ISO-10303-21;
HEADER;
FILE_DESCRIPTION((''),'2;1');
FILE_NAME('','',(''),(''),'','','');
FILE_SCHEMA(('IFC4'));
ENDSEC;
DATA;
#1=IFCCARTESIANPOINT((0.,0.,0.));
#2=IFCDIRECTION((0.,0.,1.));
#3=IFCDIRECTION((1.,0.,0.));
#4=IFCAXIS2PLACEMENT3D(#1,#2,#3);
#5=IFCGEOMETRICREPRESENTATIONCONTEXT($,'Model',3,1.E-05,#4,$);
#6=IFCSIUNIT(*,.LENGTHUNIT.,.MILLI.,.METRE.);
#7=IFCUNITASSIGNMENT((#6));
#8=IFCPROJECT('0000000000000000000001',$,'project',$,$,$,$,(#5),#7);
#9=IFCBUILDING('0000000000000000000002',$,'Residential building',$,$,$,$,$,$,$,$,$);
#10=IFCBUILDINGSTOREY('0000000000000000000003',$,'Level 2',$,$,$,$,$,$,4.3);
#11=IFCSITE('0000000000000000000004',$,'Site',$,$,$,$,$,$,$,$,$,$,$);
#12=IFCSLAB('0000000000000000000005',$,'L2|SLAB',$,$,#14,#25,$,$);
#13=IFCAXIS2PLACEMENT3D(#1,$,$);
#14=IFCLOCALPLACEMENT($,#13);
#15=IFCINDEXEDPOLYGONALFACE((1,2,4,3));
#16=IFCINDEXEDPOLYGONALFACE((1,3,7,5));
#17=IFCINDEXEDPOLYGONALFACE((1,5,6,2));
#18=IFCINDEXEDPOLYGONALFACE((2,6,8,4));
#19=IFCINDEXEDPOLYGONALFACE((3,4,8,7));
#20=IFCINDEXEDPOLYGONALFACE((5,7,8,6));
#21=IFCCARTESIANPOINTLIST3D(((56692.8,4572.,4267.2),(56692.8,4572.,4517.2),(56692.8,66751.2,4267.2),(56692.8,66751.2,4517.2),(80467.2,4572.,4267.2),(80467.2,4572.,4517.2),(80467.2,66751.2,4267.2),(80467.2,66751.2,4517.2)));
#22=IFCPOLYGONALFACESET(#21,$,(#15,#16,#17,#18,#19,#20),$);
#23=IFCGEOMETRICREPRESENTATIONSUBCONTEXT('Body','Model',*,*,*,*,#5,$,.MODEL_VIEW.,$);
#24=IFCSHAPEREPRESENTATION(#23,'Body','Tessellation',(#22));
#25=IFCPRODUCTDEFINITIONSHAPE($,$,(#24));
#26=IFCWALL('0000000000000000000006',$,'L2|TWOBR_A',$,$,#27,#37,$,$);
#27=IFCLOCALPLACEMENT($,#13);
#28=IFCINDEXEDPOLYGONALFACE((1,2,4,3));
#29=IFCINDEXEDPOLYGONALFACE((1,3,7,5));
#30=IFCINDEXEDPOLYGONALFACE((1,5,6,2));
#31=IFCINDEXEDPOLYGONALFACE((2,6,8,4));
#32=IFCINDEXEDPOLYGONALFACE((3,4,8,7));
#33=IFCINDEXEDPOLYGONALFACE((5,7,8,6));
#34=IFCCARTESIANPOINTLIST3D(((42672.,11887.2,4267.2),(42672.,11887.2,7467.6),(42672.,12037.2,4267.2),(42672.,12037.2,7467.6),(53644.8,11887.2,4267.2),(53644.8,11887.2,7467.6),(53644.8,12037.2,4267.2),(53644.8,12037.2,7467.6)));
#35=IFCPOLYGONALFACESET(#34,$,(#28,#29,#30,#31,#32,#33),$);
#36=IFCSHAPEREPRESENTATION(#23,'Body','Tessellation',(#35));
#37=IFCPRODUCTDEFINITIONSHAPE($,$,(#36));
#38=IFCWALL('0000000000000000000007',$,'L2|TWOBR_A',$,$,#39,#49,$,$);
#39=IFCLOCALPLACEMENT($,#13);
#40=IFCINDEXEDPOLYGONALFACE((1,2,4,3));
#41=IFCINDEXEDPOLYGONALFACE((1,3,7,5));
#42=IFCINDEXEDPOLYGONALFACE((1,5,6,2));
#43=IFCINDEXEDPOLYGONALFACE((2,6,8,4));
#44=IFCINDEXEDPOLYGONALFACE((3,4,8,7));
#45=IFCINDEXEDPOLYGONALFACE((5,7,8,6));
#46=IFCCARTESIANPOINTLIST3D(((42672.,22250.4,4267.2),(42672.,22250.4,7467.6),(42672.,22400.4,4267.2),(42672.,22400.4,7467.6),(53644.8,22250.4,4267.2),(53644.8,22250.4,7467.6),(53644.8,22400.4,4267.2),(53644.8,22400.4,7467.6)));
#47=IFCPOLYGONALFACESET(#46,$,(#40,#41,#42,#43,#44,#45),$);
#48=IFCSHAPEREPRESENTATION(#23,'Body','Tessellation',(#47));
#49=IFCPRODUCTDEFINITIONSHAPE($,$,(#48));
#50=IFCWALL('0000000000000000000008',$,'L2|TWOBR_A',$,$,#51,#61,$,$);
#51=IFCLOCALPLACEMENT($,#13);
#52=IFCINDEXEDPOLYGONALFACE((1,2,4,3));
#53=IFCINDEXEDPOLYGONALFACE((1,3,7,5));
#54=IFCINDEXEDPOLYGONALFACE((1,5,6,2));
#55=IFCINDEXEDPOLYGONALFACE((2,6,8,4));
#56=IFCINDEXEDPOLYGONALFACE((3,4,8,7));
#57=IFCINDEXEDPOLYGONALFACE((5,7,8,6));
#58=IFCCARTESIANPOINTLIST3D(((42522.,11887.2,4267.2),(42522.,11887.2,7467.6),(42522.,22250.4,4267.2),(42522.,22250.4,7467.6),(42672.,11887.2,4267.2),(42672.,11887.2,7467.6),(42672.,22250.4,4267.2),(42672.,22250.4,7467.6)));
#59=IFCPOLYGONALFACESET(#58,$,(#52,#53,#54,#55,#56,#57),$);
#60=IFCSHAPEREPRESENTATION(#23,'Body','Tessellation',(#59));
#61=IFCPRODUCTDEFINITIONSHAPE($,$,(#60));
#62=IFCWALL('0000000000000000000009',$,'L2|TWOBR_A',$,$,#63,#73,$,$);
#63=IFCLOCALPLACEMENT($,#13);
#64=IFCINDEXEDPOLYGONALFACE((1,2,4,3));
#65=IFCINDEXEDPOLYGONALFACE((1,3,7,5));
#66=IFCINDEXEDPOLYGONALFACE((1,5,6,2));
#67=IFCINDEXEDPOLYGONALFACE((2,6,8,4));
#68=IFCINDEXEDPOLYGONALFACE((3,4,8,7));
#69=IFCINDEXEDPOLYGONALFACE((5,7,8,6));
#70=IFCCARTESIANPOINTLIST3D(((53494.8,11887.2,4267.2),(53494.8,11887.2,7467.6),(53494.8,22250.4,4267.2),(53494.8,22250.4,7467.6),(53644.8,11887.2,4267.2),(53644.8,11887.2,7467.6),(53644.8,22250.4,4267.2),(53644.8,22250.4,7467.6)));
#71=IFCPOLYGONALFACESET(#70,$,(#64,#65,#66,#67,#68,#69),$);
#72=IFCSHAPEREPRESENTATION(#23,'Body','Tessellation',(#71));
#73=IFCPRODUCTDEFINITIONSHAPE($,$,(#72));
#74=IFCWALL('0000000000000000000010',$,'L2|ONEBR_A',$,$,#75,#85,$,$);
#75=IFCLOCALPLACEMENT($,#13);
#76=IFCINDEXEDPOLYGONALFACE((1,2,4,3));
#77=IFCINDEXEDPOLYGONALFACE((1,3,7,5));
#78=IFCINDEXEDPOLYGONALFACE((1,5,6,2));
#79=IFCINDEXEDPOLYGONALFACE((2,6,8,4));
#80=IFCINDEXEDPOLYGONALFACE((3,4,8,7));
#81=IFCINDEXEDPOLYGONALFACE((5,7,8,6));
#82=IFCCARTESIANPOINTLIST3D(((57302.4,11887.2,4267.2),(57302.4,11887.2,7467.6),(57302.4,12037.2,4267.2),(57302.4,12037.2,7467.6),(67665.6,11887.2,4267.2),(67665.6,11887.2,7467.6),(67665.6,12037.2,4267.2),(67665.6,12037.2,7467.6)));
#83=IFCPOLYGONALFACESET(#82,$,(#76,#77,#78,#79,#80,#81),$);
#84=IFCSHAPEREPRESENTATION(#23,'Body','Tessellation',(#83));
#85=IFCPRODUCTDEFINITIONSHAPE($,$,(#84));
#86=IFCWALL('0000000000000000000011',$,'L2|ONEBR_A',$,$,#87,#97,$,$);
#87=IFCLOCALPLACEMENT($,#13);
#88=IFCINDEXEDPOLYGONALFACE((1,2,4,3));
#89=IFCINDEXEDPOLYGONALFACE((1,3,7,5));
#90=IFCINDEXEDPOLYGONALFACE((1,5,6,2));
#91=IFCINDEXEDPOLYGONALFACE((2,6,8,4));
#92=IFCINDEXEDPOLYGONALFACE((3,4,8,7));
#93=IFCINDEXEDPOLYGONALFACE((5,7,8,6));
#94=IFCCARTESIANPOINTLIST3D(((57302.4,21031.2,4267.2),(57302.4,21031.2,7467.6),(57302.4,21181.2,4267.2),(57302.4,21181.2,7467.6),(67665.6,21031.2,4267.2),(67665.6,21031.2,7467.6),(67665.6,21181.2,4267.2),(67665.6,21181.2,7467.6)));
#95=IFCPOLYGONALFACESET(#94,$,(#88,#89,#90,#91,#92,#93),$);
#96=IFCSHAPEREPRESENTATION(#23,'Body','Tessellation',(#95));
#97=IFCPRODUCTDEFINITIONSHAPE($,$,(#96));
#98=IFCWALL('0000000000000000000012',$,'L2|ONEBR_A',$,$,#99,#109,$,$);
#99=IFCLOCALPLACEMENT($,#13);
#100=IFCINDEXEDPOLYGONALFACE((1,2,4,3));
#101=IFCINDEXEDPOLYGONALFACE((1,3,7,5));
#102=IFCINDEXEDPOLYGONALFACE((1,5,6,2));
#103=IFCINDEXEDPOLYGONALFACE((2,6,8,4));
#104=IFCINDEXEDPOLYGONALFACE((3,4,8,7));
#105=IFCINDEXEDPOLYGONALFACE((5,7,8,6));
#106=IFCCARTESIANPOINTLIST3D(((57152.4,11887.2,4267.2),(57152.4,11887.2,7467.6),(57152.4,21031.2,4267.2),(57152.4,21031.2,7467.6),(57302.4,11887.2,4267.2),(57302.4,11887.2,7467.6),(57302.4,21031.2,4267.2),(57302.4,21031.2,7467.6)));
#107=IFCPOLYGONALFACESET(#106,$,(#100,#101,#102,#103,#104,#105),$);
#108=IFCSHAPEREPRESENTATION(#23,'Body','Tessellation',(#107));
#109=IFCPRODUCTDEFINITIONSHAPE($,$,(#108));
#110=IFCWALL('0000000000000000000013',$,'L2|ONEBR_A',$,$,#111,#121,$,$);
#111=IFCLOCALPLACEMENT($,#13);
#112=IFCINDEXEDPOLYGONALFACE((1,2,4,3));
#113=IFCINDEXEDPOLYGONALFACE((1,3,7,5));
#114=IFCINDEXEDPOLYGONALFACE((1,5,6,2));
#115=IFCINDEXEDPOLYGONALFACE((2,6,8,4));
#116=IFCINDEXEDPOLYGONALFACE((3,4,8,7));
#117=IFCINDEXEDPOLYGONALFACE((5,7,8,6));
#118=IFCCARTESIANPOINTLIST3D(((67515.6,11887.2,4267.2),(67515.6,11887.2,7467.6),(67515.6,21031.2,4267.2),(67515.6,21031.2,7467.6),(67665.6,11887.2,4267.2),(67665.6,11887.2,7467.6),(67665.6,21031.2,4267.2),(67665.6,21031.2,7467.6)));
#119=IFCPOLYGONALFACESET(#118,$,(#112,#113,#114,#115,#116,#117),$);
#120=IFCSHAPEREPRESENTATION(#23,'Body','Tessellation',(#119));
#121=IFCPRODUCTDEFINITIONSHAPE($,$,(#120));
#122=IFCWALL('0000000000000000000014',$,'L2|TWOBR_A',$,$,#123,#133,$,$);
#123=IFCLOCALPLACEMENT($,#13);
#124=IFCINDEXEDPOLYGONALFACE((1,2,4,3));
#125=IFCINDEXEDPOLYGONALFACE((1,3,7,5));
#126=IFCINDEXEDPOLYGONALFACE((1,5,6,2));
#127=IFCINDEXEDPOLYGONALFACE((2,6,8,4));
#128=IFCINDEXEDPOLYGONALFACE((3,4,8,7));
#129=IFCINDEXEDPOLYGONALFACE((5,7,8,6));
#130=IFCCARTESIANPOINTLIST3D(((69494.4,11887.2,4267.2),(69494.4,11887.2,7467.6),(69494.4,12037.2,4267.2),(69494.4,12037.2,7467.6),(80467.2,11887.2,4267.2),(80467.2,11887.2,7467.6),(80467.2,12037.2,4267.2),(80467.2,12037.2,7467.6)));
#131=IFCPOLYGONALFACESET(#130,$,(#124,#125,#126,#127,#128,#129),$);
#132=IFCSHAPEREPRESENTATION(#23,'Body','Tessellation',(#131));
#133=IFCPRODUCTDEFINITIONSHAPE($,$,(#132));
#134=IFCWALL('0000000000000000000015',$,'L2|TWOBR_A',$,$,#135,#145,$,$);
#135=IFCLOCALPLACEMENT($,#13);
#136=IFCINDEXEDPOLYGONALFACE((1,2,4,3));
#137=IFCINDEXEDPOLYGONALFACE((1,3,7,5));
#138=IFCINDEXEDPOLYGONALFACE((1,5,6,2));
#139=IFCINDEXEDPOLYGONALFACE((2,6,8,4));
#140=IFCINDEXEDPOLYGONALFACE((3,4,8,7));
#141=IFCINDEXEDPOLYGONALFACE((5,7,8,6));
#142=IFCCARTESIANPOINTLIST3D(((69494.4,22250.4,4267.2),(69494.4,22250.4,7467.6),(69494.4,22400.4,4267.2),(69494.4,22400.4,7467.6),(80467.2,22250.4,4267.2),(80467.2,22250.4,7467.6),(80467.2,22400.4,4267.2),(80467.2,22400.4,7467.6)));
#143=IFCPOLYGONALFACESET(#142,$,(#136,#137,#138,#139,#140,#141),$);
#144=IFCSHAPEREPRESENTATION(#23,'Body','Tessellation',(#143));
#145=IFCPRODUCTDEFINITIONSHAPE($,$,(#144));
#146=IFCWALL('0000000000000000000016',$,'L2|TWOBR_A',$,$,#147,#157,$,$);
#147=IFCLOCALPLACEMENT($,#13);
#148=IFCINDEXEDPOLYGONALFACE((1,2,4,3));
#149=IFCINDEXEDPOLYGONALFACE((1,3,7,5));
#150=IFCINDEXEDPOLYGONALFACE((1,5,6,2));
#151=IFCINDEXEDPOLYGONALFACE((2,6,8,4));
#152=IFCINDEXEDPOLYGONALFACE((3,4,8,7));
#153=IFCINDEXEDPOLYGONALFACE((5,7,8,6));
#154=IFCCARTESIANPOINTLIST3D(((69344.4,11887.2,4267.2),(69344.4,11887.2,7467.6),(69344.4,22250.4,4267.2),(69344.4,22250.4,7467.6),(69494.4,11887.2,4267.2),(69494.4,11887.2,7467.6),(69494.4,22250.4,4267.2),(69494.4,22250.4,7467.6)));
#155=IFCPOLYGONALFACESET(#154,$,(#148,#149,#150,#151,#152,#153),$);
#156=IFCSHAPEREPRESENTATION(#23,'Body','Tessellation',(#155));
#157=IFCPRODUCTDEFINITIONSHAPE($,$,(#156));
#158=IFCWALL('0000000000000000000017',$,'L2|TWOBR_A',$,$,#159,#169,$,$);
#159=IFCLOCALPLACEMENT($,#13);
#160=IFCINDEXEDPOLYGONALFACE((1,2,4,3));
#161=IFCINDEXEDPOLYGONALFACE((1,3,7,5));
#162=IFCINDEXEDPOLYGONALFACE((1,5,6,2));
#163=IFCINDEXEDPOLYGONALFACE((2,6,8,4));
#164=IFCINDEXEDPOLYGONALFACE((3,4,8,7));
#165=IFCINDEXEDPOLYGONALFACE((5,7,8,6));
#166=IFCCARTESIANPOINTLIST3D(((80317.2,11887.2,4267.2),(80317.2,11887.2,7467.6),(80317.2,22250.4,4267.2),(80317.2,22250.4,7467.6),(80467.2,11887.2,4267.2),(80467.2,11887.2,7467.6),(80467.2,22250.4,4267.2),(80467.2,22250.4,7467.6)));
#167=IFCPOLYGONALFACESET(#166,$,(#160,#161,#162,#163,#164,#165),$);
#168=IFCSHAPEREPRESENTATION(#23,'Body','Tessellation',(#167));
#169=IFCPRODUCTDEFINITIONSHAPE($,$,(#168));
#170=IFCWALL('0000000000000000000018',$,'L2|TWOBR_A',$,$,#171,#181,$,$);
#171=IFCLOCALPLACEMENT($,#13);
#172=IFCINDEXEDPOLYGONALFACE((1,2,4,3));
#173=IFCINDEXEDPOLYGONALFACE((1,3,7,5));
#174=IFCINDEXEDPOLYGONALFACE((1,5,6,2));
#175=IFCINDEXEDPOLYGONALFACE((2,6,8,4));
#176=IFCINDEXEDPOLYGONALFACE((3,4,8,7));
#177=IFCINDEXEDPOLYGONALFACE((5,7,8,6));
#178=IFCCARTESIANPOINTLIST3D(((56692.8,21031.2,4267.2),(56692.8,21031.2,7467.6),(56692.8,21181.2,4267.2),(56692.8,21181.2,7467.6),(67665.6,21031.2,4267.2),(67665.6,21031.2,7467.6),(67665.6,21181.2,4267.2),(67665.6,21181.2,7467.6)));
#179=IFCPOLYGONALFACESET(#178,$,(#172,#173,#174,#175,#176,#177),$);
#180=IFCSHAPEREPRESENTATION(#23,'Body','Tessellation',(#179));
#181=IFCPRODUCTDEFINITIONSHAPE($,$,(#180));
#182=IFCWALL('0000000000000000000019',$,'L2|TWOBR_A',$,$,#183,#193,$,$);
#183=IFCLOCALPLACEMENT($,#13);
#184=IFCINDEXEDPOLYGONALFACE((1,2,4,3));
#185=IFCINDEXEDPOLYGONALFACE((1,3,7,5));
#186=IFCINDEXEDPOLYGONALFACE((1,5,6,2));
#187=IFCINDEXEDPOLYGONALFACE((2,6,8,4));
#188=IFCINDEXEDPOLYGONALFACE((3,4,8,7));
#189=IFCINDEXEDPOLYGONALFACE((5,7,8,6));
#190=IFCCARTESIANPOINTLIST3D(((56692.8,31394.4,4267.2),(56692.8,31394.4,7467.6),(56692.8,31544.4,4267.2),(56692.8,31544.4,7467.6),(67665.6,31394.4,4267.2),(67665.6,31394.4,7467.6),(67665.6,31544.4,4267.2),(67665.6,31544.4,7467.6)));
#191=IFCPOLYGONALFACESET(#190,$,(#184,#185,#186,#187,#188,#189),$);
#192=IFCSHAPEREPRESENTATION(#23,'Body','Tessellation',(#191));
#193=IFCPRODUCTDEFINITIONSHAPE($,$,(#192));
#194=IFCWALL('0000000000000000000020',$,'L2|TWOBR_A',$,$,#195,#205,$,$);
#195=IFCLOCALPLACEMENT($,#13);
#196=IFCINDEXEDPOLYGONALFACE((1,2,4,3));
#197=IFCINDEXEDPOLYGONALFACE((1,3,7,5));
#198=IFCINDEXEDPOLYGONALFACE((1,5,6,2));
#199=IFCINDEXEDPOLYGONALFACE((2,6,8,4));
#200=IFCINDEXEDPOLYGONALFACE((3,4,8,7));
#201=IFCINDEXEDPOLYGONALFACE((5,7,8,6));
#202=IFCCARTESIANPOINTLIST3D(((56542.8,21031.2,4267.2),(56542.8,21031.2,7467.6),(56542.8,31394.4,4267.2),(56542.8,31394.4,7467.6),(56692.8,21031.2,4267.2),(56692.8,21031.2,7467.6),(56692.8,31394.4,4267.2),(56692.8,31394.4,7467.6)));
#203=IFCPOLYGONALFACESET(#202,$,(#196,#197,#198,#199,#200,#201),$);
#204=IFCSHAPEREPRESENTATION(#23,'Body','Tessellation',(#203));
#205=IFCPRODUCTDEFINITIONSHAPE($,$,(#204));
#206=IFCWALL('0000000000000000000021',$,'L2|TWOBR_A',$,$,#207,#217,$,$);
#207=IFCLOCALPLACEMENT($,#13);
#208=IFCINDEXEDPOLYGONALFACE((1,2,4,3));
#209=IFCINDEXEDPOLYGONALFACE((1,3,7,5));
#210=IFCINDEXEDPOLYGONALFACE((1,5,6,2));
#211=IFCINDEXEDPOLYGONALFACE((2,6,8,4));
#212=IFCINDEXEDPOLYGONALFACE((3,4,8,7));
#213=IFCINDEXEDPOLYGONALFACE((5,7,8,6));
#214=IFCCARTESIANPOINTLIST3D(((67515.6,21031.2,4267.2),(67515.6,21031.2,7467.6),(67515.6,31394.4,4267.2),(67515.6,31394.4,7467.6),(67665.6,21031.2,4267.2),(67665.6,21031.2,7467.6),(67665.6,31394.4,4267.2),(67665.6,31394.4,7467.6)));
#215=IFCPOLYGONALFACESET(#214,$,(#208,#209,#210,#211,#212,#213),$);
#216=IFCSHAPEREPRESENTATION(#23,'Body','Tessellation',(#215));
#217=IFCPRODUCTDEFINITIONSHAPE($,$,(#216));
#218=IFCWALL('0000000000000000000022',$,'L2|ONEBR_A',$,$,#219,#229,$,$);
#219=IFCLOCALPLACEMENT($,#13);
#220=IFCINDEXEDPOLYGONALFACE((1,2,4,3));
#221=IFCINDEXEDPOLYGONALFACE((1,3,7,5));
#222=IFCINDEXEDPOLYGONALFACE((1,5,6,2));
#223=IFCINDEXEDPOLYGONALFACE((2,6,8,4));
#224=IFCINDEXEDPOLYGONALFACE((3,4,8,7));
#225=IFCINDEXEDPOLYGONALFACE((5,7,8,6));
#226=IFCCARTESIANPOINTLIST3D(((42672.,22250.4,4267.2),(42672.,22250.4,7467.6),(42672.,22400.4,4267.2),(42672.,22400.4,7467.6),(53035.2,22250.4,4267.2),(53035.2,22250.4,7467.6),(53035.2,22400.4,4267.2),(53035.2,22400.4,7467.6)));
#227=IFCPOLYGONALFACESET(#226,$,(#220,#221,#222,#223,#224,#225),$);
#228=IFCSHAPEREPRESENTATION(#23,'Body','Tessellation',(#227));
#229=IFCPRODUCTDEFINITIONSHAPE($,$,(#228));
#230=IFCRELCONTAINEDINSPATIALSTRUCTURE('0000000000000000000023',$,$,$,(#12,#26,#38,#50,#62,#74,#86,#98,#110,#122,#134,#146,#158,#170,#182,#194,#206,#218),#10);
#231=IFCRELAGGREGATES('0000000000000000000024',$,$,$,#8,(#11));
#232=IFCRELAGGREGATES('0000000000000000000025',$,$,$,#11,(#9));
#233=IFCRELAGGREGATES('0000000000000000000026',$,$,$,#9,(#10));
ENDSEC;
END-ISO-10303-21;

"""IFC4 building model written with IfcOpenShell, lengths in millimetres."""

from ifc_helpers import new_model, si_unit, frame, origin_with_axes, place, context, subcontext, project, spatial, indexed_curve, outline, extrude, element, save


model = new_model("IFC4")

# Units and contexts
model_context = context("Model", 3, precision=1e-05, world=origin_with_axes())
body_context = subcontext(model_context, "Body", "Model", "MODEL_VIEW")
ifc_project = project(units=[si_unit("LENGTHUNIT", "METRE", prefix="MILLI")], contexts=[model_context])

# Site, building, storey
site = spatial("IfcSite", under=ifc_project, Name="Site")
building = spatial("IfcBuilding", under=site, Name="Residential building")
storey = spatial("IfcBuildingStorey", under=building, Name="Level 2", Elevation=4.3)

# Slab
slab_placement = place(None, frame((56692.8, 4572.0, 4267.2), z_axis=(0.0, 0.0, 1.0), x_axis=(1.0, 0.0, 0.0)))
element("IfcSlab", 1, at=slab_placement, inside=storey, Name="L2|SLAB", context=body_context, shape_type="SweptSolid", body=[
    extrude(outline(indexed_curve([(0.0, 0.0), (23774.4, 0.0), (23774.4, 62179.2), (0.0, 62179.2), (0.0, 0.0)])), None, (0.0, 0.0, 1.0), 250.0),
])

# Walls
for number, where, z_axis, x_axis, name in (
    (2, (42672.0, 11887.2, 4267.2), (0.0, 0.0, 1.0), (1.0, 0.0, 0.0), "L2|TWOBR_A"),
    (3, (42672.0, 22250.4, 4267.2), (0.0, 0.0, 1.0), (1.0, 0.0, 0.0), "L2|TWOBR_A"),
):
    element("IfcWall", number, at=place(None, frame(where, z_axis=z_axis, x_axis=x_axis)), inside=storey, Name=name, context=body_context, shape_type="SweptSolid", body=[
        extrude(outline(indexed_curve([(0.0, 0.0), (0.0, 150.0), (10972.8, 150.0), (10972.8, 0.0), (0.0, 0.0)], self_intersect=False)), origin_with_axes(), (0.0, 0.0, 1.0), 3200.4),
    ])
for number, where, z_axis, x_axis, name in (
    (4, (42672.0, 11887.2, 4267.2), (0.0, 0.0, 1.0), (0.0, 1.0, 0.0), "L2|TWOBR_A"),
    (5, (53644.8, 11887.2, 4267.2), (0.0, 0.0, 1.0), (0.0, 1.0, 0.0), "L2|TWOBR_A"),
    (6, (57302.4, 11887.2, 4267.2), (0.0, 0.0, 1.0), (1.0, 0.0, 0.0), "L2|ONEBR_A"),
    (7, (57302.4, 21031.2, 4267.2), (0.0, 0.0, 1.0), (1.0, 0.0, 0.0), "L2|ONEBR_A"),
):
    element("IfcWall", number, at=place(None, frame(where, z_axis=z_axis, x_axis=x_axis)), inside=storey, Name=name, context=body_context, shape_type="SweptSolid", body=[
        extrude(outline(indexed_curve([(0.0, 0.0), (0.0, 150.0), (10363.2, 150.0), (10363.2, 0.0), (0.0, 0.0)], self_intersect=False)), origin_with_axes(), (0.0, 0.0, 1.0), 3200.4),
    ])
for number, where, z_axis, x_axis, name in (
    (8, (57302.4, 11887.2, 4267.2), (0.0, 0.0, 1.0), (0.0, 1.0, 0.0), "L2|ONEBR_A"),
    (9, (67665.6, 11887.2, 4267.2), (0.0, 0.0, 1.0), (0.0, 1.0, 0.0), "L2|ONEBR_A"),
):
    element("IfcWall", number, at=place(None, frame(where, z_axis=z_axis, x_axis=x_axis)), inside=storey, Name=name, context=body_context, shape_type="SweptSolid", body=[
        extrude(outline(indexed_curve([(0.0, 0.0), (0.0, 150.0), (9144.0, 150.0), (9144.0, 0.0), (0.0, 0.0)], self_intersect=False)), origin_with_axes(), (0.0, 0.0, 1.0), 3200.4),
    ])
for number, where, z_axis, x_axis, name in (
    (10, (69494.4, 11887.2, 4267.2), (0.0, 0.0, 1.0), (1.0, 0.0, 0.0), "L2|TWOBR_A"),
    (11, (69494.4, 22250.4, 4267.2), (0.0, 0.0, 1.0), (1.0, 0.0, 0.0), "L2|TWOBR_A"),
):
    element("IfcWall", number, at=place(None, frame(where, z_axis=z_axis, x_axis=x_axis)), inside=storey, Name=name, context=body_context, shape_type="SweptSolid", body=[
        extrude(outline(indexed_curve([(0.0, 0.0), (0.0, 150.0), (10972.8, 150.0), (10972.8, 0.0), (0.0, 0.0)], self_intersect=False)), origin_with_axes(), (0.0, 0.0, 1.0), 3200.4),
    ])
for number, where, z_axis, x_axis, name in (
    (12, (69494.4, 11887.2, 4267.2), (0.0, 0.0, 1.0), (0.0, 1.0, 0.0), "L2|TWOBR_A"),
    (13, (80467.2, 11887.2, 4267.2), (0.0, 0.0, 1.0), (0.0, 1.0, 0.0), "L2|TWOBR_A"),
):
    element("IfcWall", number, at=place(None, frame(where, z_axis=z_axis, x_axis=x_axis)), inside=storey, Name=name, context=body_context, shape_type="SweptSolid", body=[
        extrude(outline(indexed_curve([(0.0, 0.0), (0.0, 150.0), (10363.2, 150.0), (10363.2, 0.0), (0.0, 0.0)], self_intersect=False)), origin_with_axes(), (0.0, 0.0, 1.0), 3200.4),
    ])
for number, where, z_axis, x_axis, name in (
    (14, (56692.8, 21031.2, 4267.2), (0.0, 0.0, 1.0), (1.0, 0.0, 0.0), "L2|TWOBR_A"),
    (15, (56692.8, 31394.4, 4267.2), (0.0, 0.0, 1.0), (1.0, 0.0, 0.0), "L2|TWOBR_A"),
):
    element("IfcWall", number, at=place(None, frame(where, z_axis=z_axis, x_axis=x_axis)), inside=storey, Name=name, context=body_context, shape_type="SweptSolid", body=[
        extrude(outline(indexed_curve([(0.0, 0.0), (0.0, 150.0), (10972.8, 150.0), (10972.8, 0.0), (0.0, 0.0)], self_intersect=False)), origin_with_axes(), (0.0, 0.0, 1.0), 3200.4),
    ])
for number, where, z_axis, x_axis, name in (
    (16, (56692.8, 21031.2, 4267.2), (0.0, 0.0, 1.0), (0.0, 1.0, 0.0), "L2|TWOBR_A"),
    (17, (67665.6, 21031.2, 4267.2), (0.0, 0.0, 1.0), (0.0, 1.0, 0.0), "L2|TWOBR_A"),
    (18, (42672.0, 22250.4, 4267.2), (0.0, 0.0, 1.0), (1.0, 0.0, 0.0), "L2|ONEBR_A"),
):
    element("IfcWall", number, at=place(None, frame(where, z_axis=z_axis, x_axis=x_axis)), inside=storey, Name=name, context=body_context, shape_type="SweptSolid", body=[
        extrude(outline(indexed_curve([(0.0, 0.0), (0.0, 150.0), (10363.2, 150.0), (10363.2, 0.0), (0.0, 0.0)], self_intersect=False)), origin_with_axes(), (0.0, 0.0, 1.0), 3200.4),
    ])

save(model, "model.ifc")
